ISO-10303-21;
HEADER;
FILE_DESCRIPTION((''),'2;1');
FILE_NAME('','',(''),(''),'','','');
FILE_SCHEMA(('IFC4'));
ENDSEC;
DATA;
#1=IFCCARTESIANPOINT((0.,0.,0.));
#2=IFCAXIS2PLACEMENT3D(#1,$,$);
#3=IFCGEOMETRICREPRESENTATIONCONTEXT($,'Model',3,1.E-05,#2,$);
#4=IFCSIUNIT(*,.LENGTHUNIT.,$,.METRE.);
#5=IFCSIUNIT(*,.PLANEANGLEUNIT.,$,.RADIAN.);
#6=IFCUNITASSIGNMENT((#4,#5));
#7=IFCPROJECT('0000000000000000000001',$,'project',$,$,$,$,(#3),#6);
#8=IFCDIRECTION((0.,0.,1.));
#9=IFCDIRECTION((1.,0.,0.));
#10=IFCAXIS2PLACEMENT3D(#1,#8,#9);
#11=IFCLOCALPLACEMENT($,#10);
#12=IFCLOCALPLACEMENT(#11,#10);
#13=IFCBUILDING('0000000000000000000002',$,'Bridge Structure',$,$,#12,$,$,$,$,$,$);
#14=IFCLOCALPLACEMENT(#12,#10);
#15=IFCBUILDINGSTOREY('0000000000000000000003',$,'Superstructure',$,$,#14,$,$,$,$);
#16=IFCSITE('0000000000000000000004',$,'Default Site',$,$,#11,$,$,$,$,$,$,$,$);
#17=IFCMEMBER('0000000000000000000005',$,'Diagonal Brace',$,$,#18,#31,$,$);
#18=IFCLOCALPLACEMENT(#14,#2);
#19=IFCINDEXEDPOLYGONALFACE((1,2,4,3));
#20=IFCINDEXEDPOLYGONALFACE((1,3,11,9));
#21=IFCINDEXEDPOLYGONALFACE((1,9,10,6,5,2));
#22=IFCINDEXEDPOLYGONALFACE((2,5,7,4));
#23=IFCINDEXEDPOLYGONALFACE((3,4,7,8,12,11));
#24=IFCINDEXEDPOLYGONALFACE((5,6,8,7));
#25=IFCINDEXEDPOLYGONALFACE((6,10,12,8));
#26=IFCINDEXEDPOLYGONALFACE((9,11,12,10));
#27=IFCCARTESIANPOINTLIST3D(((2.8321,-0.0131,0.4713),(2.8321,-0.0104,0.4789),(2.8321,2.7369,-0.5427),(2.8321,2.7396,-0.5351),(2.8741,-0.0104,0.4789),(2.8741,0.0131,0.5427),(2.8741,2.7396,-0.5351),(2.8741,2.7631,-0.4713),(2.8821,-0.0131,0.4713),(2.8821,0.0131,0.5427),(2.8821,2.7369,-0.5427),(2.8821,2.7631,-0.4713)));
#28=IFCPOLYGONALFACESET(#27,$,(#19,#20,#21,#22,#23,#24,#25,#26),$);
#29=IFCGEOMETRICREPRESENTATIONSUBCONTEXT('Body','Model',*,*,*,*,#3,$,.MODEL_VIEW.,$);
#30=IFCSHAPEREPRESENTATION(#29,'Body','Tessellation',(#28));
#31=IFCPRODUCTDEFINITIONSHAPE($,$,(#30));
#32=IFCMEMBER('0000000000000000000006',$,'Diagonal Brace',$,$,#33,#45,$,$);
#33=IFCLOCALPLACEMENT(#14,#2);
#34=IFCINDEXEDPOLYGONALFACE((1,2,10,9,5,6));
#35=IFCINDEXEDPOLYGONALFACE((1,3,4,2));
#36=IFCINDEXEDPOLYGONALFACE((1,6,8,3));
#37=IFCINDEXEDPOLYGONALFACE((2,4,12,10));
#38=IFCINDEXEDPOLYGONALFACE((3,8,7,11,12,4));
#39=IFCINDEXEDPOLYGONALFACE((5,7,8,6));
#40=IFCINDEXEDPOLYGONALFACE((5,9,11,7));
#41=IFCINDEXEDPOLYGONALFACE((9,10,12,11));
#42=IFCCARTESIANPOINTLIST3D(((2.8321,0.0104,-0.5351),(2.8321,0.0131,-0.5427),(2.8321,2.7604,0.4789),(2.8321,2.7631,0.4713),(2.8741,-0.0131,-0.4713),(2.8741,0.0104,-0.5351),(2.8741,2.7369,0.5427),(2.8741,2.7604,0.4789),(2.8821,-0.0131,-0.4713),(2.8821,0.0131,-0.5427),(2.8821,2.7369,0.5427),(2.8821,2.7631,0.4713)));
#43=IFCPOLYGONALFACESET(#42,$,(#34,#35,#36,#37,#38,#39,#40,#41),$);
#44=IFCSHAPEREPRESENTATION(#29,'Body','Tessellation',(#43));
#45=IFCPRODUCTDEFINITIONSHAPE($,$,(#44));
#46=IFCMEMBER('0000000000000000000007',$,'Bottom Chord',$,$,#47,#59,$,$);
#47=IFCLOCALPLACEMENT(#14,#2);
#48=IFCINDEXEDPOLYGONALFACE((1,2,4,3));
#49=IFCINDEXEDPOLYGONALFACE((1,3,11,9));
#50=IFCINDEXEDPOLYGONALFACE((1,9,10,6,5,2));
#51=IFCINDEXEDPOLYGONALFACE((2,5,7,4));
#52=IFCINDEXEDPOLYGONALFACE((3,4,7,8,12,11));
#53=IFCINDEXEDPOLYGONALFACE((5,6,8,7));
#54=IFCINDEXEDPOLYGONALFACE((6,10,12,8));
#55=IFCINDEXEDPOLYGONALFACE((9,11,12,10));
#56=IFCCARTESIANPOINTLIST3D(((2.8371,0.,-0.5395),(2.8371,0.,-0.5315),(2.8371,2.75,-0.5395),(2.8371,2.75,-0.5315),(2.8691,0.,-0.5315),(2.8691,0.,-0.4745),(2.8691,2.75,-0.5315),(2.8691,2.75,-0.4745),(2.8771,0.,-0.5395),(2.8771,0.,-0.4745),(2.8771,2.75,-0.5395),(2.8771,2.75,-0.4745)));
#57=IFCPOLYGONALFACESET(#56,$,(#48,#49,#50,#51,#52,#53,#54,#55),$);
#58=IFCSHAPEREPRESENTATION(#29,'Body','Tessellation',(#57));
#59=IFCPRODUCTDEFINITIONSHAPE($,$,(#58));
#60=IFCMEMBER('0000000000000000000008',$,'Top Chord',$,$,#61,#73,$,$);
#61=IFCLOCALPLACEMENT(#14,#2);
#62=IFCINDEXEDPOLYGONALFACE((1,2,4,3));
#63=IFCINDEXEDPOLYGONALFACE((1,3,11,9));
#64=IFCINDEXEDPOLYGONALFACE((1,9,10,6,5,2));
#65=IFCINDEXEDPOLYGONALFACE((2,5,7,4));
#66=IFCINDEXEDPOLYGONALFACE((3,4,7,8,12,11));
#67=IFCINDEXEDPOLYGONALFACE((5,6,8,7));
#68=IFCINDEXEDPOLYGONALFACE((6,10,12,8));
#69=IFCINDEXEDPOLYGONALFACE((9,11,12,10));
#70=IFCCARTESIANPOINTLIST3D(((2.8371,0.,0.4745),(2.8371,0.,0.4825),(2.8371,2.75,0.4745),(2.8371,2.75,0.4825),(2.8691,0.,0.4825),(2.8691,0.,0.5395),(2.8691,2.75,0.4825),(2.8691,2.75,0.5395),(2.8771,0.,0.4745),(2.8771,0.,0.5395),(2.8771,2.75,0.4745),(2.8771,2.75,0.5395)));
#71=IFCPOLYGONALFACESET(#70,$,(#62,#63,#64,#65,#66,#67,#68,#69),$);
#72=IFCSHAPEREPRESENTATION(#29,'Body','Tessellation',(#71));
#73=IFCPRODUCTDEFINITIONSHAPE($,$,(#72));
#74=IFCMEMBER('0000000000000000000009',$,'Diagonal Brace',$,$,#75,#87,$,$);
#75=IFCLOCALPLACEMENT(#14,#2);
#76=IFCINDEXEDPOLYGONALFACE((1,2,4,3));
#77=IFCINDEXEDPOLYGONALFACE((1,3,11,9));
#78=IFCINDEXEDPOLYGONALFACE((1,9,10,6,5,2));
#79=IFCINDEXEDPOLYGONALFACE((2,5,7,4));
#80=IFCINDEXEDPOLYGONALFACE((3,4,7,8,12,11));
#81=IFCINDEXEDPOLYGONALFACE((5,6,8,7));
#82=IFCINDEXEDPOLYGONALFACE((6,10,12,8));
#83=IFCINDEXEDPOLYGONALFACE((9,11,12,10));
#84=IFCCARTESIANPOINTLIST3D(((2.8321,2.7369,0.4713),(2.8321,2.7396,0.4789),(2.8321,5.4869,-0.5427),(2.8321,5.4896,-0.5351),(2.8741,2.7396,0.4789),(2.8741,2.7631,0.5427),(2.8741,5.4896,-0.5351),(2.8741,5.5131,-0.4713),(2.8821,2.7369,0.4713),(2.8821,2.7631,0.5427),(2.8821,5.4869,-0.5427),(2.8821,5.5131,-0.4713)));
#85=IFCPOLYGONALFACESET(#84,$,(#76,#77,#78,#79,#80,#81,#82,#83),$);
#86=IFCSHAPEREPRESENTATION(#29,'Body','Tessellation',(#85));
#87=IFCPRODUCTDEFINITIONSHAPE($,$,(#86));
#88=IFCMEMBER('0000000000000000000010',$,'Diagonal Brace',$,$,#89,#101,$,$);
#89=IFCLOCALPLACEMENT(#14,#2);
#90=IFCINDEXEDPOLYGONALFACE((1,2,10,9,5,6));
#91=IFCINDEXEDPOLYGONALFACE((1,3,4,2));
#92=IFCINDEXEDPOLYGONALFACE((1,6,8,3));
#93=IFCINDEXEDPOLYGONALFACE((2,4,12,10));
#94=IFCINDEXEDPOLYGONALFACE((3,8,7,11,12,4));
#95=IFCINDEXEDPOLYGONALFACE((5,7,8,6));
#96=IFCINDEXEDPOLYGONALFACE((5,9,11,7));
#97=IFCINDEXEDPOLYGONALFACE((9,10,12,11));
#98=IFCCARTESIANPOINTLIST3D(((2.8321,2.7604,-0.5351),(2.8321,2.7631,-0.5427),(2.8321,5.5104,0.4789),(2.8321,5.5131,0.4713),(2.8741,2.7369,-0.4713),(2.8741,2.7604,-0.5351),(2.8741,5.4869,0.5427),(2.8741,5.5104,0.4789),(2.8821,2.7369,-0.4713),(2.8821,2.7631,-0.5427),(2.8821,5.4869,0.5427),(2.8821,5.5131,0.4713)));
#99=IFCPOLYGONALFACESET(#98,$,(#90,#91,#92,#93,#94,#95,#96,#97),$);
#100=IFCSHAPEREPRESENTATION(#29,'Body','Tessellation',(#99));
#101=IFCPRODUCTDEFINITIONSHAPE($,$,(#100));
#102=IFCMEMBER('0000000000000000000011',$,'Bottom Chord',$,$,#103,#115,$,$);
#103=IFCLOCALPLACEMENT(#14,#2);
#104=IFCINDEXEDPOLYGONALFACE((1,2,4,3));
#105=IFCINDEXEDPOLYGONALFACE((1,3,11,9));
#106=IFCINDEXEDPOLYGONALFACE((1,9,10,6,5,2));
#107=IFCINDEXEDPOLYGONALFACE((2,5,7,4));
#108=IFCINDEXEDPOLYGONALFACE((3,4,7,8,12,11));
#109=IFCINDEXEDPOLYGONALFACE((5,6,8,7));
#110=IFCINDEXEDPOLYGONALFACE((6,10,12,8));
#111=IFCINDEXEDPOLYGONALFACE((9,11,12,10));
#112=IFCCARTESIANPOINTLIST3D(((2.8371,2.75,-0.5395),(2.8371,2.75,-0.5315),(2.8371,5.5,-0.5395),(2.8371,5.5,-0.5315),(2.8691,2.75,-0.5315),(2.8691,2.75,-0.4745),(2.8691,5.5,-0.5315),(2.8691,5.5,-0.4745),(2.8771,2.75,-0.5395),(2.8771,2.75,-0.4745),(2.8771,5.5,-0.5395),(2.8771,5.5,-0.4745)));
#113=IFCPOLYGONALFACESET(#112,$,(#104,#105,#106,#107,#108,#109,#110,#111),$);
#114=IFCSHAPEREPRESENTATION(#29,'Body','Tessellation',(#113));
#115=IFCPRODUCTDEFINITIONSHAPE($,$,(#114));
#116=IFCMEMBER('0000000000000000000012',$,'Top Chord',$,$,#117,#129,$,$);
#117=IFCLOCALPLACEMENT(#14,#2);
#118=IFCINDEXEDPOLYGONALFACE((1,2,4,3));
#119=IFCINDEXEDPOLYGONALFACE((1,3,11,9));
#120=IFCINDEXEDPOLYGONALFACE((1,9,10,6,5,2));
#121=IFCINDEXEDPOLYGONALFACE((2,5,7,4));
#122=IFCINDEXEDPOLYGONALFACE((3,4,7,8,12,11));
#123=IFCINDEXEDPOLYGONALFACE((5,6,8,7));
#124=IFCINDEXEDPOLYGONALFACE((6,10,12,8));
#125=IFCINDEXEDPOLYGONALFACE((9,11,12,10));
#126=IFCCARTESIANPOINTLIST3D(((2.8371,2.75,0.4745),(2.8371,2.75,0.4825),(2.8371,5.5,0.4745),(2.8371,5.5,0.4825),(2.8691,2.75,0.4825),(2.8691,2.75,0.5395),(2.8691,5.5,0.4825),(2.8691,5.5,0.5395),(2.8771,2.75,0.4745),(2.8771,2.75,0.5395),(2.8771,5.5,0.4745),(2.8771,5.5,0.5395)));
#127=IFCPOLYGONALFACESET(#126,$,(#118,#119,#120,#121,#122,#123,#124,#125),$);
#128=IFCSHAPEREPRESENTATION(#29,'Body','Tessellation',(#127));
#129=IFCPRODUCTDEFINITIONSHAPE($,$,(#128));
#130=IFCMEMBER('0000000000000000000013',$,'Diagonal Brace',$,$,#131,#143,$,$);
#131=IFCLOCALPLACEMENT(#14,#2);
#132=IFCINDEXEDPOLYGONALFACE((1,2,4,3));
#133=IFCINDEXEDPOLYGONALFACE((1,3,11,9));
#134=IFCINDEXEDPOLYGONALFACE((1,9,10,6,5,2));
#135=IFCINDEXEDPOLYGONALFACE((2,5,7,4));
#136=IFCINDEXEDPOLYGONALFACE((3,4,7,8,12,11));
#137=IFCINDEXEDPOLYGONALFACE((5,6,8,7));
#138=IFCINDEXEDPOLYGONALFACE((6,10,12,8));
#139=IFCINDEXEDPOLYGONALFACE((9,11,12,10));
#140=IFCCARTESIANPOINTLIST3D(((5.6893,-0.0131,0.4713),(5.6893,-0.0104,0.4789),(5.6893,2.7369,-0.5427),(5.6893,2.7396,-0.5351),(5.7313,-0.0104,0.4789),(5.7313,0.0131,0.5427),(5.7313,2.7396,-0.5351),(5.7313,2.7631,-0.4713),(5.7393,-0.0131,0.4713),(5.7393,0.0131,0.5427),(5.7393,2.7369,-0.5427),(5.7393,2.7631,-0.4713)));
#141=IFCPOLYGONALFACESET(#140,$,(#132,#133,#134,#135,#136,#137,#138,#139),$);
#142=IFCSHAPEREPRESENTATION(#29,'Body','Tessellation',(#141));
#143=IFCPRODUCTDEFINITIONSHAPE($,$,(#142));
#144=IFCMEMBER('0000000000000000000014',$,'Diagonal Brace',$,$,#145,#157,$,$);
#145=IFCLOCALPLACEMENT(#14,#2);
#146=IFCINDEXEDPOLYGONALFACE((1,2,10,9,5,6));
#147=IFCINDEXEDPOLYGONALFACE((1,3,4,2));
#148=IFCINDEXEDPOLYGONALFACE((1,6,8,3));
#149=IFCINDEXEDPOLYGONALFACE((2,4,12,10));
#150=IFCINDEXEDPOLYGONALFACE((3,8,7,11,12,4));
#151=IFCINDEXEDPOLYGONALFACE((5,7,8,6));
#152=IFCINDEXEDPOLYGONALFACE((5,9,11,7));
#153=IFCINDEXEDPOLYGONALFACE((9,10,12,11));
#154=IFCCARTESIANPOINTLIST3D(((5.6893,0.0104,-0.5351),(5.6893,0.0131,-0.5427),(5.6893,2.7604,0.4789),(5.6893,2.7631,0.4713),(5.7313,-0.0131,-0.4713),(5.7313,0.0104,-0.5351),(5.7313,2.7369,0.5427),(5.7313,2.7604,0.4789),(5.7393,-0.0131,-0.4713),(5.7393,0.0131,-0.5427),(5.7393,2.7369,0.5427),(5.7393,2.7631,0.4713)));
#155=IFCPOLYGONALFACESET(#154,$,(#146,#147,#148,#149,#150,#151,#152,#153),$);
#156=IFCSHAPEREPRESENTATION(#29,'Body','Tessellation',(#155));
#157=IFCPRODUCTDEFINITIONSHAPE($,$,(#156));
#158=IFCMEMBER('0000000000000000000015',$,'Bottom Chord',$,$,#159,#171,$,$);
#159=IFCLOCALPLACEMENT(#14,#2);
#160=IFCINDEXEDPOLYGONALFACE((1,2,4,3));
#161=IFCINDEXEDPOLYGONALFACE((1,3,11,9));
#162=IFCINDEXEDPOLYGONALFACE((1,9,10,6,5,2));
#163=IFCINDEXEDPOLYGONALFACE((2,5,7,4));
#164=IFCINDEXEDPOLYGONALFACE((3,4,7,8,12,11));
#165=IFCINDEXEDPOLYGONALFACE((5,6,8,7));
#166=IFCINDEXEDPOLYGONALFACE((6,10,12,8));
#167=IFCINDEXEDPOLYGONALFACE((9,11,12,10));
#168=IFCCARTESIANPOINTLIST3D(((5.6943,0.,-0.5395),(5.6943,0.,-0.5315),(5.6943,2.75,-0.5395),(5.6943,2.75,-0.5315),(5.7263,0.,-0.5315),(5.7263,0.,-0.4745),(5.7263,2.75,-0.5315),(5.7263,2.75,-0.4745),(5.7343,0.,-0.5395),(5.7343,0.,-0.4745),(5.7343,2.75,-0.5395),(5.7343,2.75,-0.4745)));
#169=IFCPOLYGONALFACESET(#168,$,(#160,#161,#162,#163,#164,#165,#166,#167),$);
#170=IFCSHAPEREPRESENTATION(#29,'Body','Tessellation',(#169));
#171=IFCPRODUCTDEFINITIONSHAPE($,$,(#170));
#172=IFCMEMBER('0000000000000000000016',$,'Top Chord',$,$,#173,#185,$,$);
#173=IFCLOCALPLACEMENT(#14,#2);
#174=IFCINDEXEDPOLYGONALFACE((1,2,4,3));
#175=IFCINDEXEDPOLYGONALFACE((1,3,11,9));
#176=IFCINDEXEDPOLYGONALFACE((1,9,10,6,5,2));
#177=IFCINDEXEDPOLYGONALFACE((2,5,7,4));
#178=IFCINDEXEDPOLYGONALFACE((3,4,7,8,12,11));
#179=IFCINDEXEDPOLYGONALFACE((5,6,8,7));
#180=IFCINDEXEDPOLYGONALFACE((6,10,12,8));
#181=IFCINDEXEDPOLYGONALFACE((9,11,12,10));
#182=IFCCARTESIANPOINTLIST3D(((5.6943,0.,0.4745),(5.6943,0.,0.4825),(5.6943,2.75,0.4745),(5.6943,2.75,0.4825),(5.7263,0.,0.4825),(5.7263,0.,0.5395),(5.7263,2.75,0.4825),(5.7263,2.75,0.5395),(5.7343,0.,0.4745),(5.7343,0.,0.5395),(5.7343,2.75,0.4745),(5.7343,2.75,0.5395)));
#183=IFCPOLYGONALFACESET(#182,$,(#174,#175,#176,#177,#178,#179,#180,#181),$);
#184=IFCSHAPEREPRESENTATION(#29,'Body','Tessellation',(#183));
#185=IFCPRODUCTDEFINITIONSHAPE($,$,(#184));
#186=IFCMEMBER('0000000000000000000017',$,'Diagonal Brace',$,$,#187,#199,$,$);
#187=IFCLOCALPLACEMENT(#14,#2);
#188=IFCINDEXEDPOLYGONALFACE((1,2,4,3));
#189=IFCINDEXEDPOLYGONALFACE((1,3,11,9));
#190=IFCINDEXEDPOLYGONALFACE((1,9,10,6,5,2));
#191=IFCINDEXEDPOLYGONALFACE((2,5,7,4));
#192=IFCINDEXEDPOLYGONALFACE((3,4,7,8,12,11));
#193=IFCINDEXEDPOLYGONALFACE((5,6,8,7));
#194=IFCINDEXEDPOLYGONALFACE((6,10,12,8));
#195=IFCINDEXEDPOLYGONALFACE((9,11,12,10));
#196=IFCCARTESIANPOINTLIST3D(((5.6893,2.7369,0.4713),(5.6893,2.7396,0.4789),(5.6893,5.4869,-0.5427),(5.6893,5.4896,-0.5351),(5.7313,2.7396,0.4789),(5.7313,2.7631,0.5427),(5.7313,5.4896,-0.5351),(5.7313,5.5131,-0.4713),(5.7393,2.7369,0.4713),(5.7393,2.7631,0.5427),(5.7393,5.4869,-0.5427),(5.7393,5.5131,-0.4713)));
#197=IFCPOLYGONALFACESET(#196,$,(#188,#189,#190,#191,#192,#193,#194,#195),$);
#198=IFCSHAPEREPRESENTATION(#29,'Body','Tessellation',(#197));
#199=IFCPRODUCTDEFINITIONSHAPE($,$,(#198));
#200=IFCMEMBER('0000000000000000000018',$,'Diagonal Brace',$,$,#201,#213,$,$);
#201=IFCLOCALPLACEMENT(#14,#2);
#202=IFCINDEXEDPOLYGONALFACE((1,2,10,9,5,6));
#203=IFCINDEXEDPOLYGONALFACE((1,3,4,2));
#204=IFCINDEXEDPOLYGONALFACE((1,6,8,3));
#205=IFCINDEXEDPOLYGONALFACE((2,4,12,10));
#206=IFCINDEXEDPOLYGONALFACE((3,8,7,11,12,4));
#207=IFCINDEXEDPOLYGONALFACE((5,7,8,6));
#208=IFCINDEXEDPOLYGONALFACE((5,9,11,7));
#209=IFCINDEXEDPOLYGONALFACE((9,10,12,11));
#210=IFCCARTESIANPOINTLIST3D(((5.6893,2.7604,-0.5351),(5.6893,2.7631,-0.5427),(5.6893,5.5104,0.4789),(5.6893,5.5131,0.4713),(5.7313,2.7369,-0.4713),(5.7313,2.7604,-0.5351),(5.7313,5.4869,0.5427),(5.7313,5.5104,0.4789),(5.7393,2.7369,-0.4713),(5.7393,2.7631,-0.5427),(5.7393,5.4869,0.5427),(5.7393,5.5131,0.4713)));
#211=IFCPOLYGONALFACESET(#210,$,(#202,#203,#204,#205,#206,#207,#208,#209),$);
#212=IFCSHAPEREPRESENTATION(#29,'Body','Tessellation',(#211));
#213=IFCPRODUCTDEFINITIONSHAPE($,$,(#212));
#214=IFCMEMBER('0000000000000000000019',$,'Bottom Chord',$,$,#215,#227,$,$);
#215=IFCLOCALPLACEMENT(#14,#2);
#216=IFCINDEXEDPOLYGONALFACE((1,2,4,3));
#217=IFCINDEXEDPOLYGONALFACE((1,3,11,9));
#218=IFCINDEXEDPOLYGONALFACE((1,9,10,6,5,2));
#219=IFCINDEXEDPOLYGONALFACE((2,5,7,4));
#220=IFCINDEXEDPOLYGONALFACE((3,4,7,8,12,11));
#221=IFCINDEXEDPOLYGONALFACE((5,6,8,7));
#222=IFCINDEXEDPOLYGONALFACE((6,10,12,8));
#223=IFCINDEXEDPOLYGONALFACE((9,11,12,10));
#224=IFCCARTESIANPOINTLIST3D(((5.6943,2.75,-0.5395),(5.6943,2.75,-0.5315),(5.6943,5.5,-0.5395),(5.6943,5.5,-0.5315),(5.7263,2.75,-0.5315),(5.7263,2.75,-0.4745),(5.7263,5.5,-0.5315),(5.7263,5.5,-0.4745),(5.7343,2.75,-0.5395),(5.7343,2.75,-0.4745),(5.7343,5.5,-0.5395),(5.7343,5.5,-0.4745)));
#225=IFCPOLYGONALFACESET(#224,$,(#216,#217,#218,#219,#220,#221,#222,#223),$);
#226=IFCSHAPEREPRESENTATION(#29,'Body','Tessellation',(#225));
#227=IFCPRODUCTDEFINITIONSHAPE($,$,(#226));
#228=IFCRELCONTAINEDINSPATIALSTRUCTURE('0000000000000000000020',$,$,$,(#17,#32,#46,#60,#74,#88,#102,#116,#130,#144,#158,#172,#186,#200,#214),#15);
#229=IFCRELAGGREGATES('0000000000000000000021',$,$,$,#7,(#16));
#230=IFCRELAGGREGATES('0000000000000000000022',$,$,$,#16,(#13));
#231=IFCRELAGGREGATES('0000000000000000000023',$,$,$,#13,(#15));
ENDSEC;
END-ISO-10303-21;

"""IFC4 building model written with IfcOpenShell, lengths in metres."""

from ifc_helpers import new_model, si_unit, frame, origin, origin_with_axes, origin_2d_with_axis, place, context, subcontext, project, spatial, l_section, extrude, element, save


model = new_model("IFC4")

# Units and contexts
model_context = context("Model", 3, precision=1e-05, world=origin())
body_context = subcontext(model_context, "Body", "Model", "MODEL_VIEW")
ifc_project = project(units=[si_unit("LENGTHUNIT", "METRE"), si_unit("PLANEANGLEUNIT", "RADIAN")], contexts=[model_context])

# Site, building, storey
site_placement = place(None, origin_with_axes())
site = spatial("IfcSite", under=ifc_project, at=site_placement, Name="Default Site")
building_placement = place(site_placement, origin_with_axes())
building = spatial("IfcBuilding", under=site, at=building_placement, Name="Bridge Structure")
storey_placement = place(building_placement, origin_with_axes())
storey = spatial("IfcBuildingStorey", under=building, at=storey_placement, Name="Superstructure")

# Members
for number, where, z_axis, x_axis, name in (
    (1, (2.8571, 0.0, 0.507), (0.0, 0.93825, -0.345958), (-1.0, 0.0, 0.0), "Diagonal Brace"),
    (2, (2.8571, 0.0, -0.507), (0.0, 0.93825, 0.345958), (-1.0, 0.0, 0.0), "Diagonal Brace"),
):
    element("IfcMember", number, at=place(storey_placement, frame(where, z_axis=z_axis, x_axis=x_axis)), inside=storey, Name=name, context=body_context, shape_type="SweptSolid", body=[
        extrude(l_section(Depth=0.076, Width=0.05, Thickness=0.008, at=origin_2d_with_axis()), origin_with_axes(), (0.0, 0.0, 1.0), 2.931),
    ])
for number, where, z_axis, x_axis, name in (
    (3, (2.8571, 0.0, -0.507), (0.0, 1.0, 0.0), (-1.0, 0.0, 0.0), "Bottom Chord"),
    (4, (2.8571, 0.0, 0.507), (0.0, 1.0, 0.0), (-1.0, 0.0, 0.0), "Top Chord"),
):
    element("IfcMember", number, at=place(storey_placement, frame(where, z_axis=z_axis, x_axis=x_axis)), inside=storey, Name=name, context=body_context, shape_type="SweptSolid", body=[
        extrude(l_section(Depth=0.065, Width=0.04, Thickness=0.008, at=origin_2d_with_axis()), origin_with_axes(), (0.0, 0.0, 1.0), 2.75),
    ])
for number, where, z_axis, x_axis, name in (
    (5, (2.8571, 2.75, 0.507), (0.0, 0.93825, -0.345958), (-1.0, 0.0, 0.0), "Diagonal Brace"),
    (6, (2.8571, 2.75, -0.507), (0.0, 0.93825, 0.345958), (-1.0, 0.0, 0.0), "Diagonal Brace"),
):
    element("IfcMember", number, at=place(storey_placement, frame(where, z_axis=z_axis, x_axis=x_axis)), inside=storey, Name=name, context=body_context, shape_type="SweptSolid", body=[
        extrude(l_section(Depth=0.076, Width=0.05, Thickness=0.008, at=origin_2d_with_axis()), origin_with_axes(), (0.0, 0.0, 1.0), 2.931),
    ])
for number, where, z_axis, x_axis, name in (
    (7, (2.8571, 2.75, -0.507), (0.0, 1.0, 0.0), (-1.0, 0.0, 0.0), "Bottom Chord"),
    (8, (2.8571, 2.75, 0.507), (0.0, 1.0, 0.0), (-1.0, 0.0, 0.0), "Top Chord"),
):
    element("IfcMember", number, at=place(storey_placement, frame(where, z_axis=z_axis, x_axis=x_axis)), inside=storey, Name=name, context=body_context, shape_type="SweptSolid", body=[
        extrude(l_section(Depth=0.065, Width=0.04, Thickness=0.008, at=origin_2d_with_axis()), origin_with_axes(), (0.0, 0.0, 1.0), 2.75),
    ])
for number, where, z_axis, x_axis, name in (
    (9, (5.7143, 0.0, 0.507), (0.0, 0.93825, -0.345958), (-1.0, 0.0, 0.0), "Diagonal Brace"),
    (10, (5.7143, 0.0, -0.507), (0.0, 0.93825, 0.345958), (-1.0, 0.0, 0.0), "Diagonal Brace"),
):
    element("IfcMember", number, at=place(storey_placement, frame(where, z_axis=z_axis, x_axis=x_axis)), inside=storey, Name=name, context=body_context, shape_type="SweptSolid", body=[
        extrude(l_section(Depth=0.076, Width=0.05, Thickness=0.008, at=origin_2d_with_axis()), origin_with_axes(), (0.0, 0.0, 1.0), 2.931),
    ])
for number, where, z_axis, x_axis, name in (
    (11, (5.7143, 0.0, -0.507), (0.0, 1.0, 0.0), (-1.0, 0.0, 0.0), "Bottom Chord"),
    (12, (5.7143, 0.0, 0.507), (0.0, 1.0, 0.0), (-1.0, 0.0, 0.0), "Top Chord"),
):
    element("IfcMember", number, at=place(storey_placement, frame(where, z_axis=z_axis, x_axis=x_axis)), inside=storey, Name=name, context=body_context, shape_type="SweptSolid", body=[
        extrude(l_section(Depth=0.065, Width=0.04, Thickness=0.008, at=origin_2d_with_axis()), origin_with_axes(), (0.0, 0.0, 1.0), 2.75),
    ])
for number, where, z_axis, x_axis, name in (
    (13, (5.7143, 2.75, 0.507), (0.0, 0.93825, -0.345958), (-1.0, 0.0, 0.0), "Diagonal Brace"),
    (14, (5.7143, 2.75, -0.507), (0.0, 0.93825, 0.345958), (-1.0, 0.0, 0.0), "Diagonal Brace"),
):
    element("IfcMember", number, at=place(storey_placement, frame(where, z_axis=z_axis, x_axis=x_axis)), inside=storey, Name=name, context=body_context, shape_type="SweptSolid", body=[
        extrude(l_section(Depth=0.076, Width=0.05, Thickness=0.008, at=origin_2d_with_axis()), origin_with_axes(), (0.0, 0.0, 1.0), 2.931),
    ])
for number, where, z_axis, x_axis, name in (
    (15, (5.7143, 2.75, -0.507), (0.0, 1.0, 0.0), (-1.0, 0.0, 0.0), "Bottom Chord"),
):
    element("IfcMember", number, at=place(storey_placement, frame(where, z_axis=z_axis, x_axis=x_axis)), inside=storey, Name=name, context=body_context, shape_type="SweptSolid", body=[
        extrude(l_section(Depth=0.065, Width=0.04, Thickness=0.008, at=origin_2d_with_axis()), origin_with_axes(), (0.0, 0.0, 1.0), 2.75),
    ])

save(model, "model.ifc")
